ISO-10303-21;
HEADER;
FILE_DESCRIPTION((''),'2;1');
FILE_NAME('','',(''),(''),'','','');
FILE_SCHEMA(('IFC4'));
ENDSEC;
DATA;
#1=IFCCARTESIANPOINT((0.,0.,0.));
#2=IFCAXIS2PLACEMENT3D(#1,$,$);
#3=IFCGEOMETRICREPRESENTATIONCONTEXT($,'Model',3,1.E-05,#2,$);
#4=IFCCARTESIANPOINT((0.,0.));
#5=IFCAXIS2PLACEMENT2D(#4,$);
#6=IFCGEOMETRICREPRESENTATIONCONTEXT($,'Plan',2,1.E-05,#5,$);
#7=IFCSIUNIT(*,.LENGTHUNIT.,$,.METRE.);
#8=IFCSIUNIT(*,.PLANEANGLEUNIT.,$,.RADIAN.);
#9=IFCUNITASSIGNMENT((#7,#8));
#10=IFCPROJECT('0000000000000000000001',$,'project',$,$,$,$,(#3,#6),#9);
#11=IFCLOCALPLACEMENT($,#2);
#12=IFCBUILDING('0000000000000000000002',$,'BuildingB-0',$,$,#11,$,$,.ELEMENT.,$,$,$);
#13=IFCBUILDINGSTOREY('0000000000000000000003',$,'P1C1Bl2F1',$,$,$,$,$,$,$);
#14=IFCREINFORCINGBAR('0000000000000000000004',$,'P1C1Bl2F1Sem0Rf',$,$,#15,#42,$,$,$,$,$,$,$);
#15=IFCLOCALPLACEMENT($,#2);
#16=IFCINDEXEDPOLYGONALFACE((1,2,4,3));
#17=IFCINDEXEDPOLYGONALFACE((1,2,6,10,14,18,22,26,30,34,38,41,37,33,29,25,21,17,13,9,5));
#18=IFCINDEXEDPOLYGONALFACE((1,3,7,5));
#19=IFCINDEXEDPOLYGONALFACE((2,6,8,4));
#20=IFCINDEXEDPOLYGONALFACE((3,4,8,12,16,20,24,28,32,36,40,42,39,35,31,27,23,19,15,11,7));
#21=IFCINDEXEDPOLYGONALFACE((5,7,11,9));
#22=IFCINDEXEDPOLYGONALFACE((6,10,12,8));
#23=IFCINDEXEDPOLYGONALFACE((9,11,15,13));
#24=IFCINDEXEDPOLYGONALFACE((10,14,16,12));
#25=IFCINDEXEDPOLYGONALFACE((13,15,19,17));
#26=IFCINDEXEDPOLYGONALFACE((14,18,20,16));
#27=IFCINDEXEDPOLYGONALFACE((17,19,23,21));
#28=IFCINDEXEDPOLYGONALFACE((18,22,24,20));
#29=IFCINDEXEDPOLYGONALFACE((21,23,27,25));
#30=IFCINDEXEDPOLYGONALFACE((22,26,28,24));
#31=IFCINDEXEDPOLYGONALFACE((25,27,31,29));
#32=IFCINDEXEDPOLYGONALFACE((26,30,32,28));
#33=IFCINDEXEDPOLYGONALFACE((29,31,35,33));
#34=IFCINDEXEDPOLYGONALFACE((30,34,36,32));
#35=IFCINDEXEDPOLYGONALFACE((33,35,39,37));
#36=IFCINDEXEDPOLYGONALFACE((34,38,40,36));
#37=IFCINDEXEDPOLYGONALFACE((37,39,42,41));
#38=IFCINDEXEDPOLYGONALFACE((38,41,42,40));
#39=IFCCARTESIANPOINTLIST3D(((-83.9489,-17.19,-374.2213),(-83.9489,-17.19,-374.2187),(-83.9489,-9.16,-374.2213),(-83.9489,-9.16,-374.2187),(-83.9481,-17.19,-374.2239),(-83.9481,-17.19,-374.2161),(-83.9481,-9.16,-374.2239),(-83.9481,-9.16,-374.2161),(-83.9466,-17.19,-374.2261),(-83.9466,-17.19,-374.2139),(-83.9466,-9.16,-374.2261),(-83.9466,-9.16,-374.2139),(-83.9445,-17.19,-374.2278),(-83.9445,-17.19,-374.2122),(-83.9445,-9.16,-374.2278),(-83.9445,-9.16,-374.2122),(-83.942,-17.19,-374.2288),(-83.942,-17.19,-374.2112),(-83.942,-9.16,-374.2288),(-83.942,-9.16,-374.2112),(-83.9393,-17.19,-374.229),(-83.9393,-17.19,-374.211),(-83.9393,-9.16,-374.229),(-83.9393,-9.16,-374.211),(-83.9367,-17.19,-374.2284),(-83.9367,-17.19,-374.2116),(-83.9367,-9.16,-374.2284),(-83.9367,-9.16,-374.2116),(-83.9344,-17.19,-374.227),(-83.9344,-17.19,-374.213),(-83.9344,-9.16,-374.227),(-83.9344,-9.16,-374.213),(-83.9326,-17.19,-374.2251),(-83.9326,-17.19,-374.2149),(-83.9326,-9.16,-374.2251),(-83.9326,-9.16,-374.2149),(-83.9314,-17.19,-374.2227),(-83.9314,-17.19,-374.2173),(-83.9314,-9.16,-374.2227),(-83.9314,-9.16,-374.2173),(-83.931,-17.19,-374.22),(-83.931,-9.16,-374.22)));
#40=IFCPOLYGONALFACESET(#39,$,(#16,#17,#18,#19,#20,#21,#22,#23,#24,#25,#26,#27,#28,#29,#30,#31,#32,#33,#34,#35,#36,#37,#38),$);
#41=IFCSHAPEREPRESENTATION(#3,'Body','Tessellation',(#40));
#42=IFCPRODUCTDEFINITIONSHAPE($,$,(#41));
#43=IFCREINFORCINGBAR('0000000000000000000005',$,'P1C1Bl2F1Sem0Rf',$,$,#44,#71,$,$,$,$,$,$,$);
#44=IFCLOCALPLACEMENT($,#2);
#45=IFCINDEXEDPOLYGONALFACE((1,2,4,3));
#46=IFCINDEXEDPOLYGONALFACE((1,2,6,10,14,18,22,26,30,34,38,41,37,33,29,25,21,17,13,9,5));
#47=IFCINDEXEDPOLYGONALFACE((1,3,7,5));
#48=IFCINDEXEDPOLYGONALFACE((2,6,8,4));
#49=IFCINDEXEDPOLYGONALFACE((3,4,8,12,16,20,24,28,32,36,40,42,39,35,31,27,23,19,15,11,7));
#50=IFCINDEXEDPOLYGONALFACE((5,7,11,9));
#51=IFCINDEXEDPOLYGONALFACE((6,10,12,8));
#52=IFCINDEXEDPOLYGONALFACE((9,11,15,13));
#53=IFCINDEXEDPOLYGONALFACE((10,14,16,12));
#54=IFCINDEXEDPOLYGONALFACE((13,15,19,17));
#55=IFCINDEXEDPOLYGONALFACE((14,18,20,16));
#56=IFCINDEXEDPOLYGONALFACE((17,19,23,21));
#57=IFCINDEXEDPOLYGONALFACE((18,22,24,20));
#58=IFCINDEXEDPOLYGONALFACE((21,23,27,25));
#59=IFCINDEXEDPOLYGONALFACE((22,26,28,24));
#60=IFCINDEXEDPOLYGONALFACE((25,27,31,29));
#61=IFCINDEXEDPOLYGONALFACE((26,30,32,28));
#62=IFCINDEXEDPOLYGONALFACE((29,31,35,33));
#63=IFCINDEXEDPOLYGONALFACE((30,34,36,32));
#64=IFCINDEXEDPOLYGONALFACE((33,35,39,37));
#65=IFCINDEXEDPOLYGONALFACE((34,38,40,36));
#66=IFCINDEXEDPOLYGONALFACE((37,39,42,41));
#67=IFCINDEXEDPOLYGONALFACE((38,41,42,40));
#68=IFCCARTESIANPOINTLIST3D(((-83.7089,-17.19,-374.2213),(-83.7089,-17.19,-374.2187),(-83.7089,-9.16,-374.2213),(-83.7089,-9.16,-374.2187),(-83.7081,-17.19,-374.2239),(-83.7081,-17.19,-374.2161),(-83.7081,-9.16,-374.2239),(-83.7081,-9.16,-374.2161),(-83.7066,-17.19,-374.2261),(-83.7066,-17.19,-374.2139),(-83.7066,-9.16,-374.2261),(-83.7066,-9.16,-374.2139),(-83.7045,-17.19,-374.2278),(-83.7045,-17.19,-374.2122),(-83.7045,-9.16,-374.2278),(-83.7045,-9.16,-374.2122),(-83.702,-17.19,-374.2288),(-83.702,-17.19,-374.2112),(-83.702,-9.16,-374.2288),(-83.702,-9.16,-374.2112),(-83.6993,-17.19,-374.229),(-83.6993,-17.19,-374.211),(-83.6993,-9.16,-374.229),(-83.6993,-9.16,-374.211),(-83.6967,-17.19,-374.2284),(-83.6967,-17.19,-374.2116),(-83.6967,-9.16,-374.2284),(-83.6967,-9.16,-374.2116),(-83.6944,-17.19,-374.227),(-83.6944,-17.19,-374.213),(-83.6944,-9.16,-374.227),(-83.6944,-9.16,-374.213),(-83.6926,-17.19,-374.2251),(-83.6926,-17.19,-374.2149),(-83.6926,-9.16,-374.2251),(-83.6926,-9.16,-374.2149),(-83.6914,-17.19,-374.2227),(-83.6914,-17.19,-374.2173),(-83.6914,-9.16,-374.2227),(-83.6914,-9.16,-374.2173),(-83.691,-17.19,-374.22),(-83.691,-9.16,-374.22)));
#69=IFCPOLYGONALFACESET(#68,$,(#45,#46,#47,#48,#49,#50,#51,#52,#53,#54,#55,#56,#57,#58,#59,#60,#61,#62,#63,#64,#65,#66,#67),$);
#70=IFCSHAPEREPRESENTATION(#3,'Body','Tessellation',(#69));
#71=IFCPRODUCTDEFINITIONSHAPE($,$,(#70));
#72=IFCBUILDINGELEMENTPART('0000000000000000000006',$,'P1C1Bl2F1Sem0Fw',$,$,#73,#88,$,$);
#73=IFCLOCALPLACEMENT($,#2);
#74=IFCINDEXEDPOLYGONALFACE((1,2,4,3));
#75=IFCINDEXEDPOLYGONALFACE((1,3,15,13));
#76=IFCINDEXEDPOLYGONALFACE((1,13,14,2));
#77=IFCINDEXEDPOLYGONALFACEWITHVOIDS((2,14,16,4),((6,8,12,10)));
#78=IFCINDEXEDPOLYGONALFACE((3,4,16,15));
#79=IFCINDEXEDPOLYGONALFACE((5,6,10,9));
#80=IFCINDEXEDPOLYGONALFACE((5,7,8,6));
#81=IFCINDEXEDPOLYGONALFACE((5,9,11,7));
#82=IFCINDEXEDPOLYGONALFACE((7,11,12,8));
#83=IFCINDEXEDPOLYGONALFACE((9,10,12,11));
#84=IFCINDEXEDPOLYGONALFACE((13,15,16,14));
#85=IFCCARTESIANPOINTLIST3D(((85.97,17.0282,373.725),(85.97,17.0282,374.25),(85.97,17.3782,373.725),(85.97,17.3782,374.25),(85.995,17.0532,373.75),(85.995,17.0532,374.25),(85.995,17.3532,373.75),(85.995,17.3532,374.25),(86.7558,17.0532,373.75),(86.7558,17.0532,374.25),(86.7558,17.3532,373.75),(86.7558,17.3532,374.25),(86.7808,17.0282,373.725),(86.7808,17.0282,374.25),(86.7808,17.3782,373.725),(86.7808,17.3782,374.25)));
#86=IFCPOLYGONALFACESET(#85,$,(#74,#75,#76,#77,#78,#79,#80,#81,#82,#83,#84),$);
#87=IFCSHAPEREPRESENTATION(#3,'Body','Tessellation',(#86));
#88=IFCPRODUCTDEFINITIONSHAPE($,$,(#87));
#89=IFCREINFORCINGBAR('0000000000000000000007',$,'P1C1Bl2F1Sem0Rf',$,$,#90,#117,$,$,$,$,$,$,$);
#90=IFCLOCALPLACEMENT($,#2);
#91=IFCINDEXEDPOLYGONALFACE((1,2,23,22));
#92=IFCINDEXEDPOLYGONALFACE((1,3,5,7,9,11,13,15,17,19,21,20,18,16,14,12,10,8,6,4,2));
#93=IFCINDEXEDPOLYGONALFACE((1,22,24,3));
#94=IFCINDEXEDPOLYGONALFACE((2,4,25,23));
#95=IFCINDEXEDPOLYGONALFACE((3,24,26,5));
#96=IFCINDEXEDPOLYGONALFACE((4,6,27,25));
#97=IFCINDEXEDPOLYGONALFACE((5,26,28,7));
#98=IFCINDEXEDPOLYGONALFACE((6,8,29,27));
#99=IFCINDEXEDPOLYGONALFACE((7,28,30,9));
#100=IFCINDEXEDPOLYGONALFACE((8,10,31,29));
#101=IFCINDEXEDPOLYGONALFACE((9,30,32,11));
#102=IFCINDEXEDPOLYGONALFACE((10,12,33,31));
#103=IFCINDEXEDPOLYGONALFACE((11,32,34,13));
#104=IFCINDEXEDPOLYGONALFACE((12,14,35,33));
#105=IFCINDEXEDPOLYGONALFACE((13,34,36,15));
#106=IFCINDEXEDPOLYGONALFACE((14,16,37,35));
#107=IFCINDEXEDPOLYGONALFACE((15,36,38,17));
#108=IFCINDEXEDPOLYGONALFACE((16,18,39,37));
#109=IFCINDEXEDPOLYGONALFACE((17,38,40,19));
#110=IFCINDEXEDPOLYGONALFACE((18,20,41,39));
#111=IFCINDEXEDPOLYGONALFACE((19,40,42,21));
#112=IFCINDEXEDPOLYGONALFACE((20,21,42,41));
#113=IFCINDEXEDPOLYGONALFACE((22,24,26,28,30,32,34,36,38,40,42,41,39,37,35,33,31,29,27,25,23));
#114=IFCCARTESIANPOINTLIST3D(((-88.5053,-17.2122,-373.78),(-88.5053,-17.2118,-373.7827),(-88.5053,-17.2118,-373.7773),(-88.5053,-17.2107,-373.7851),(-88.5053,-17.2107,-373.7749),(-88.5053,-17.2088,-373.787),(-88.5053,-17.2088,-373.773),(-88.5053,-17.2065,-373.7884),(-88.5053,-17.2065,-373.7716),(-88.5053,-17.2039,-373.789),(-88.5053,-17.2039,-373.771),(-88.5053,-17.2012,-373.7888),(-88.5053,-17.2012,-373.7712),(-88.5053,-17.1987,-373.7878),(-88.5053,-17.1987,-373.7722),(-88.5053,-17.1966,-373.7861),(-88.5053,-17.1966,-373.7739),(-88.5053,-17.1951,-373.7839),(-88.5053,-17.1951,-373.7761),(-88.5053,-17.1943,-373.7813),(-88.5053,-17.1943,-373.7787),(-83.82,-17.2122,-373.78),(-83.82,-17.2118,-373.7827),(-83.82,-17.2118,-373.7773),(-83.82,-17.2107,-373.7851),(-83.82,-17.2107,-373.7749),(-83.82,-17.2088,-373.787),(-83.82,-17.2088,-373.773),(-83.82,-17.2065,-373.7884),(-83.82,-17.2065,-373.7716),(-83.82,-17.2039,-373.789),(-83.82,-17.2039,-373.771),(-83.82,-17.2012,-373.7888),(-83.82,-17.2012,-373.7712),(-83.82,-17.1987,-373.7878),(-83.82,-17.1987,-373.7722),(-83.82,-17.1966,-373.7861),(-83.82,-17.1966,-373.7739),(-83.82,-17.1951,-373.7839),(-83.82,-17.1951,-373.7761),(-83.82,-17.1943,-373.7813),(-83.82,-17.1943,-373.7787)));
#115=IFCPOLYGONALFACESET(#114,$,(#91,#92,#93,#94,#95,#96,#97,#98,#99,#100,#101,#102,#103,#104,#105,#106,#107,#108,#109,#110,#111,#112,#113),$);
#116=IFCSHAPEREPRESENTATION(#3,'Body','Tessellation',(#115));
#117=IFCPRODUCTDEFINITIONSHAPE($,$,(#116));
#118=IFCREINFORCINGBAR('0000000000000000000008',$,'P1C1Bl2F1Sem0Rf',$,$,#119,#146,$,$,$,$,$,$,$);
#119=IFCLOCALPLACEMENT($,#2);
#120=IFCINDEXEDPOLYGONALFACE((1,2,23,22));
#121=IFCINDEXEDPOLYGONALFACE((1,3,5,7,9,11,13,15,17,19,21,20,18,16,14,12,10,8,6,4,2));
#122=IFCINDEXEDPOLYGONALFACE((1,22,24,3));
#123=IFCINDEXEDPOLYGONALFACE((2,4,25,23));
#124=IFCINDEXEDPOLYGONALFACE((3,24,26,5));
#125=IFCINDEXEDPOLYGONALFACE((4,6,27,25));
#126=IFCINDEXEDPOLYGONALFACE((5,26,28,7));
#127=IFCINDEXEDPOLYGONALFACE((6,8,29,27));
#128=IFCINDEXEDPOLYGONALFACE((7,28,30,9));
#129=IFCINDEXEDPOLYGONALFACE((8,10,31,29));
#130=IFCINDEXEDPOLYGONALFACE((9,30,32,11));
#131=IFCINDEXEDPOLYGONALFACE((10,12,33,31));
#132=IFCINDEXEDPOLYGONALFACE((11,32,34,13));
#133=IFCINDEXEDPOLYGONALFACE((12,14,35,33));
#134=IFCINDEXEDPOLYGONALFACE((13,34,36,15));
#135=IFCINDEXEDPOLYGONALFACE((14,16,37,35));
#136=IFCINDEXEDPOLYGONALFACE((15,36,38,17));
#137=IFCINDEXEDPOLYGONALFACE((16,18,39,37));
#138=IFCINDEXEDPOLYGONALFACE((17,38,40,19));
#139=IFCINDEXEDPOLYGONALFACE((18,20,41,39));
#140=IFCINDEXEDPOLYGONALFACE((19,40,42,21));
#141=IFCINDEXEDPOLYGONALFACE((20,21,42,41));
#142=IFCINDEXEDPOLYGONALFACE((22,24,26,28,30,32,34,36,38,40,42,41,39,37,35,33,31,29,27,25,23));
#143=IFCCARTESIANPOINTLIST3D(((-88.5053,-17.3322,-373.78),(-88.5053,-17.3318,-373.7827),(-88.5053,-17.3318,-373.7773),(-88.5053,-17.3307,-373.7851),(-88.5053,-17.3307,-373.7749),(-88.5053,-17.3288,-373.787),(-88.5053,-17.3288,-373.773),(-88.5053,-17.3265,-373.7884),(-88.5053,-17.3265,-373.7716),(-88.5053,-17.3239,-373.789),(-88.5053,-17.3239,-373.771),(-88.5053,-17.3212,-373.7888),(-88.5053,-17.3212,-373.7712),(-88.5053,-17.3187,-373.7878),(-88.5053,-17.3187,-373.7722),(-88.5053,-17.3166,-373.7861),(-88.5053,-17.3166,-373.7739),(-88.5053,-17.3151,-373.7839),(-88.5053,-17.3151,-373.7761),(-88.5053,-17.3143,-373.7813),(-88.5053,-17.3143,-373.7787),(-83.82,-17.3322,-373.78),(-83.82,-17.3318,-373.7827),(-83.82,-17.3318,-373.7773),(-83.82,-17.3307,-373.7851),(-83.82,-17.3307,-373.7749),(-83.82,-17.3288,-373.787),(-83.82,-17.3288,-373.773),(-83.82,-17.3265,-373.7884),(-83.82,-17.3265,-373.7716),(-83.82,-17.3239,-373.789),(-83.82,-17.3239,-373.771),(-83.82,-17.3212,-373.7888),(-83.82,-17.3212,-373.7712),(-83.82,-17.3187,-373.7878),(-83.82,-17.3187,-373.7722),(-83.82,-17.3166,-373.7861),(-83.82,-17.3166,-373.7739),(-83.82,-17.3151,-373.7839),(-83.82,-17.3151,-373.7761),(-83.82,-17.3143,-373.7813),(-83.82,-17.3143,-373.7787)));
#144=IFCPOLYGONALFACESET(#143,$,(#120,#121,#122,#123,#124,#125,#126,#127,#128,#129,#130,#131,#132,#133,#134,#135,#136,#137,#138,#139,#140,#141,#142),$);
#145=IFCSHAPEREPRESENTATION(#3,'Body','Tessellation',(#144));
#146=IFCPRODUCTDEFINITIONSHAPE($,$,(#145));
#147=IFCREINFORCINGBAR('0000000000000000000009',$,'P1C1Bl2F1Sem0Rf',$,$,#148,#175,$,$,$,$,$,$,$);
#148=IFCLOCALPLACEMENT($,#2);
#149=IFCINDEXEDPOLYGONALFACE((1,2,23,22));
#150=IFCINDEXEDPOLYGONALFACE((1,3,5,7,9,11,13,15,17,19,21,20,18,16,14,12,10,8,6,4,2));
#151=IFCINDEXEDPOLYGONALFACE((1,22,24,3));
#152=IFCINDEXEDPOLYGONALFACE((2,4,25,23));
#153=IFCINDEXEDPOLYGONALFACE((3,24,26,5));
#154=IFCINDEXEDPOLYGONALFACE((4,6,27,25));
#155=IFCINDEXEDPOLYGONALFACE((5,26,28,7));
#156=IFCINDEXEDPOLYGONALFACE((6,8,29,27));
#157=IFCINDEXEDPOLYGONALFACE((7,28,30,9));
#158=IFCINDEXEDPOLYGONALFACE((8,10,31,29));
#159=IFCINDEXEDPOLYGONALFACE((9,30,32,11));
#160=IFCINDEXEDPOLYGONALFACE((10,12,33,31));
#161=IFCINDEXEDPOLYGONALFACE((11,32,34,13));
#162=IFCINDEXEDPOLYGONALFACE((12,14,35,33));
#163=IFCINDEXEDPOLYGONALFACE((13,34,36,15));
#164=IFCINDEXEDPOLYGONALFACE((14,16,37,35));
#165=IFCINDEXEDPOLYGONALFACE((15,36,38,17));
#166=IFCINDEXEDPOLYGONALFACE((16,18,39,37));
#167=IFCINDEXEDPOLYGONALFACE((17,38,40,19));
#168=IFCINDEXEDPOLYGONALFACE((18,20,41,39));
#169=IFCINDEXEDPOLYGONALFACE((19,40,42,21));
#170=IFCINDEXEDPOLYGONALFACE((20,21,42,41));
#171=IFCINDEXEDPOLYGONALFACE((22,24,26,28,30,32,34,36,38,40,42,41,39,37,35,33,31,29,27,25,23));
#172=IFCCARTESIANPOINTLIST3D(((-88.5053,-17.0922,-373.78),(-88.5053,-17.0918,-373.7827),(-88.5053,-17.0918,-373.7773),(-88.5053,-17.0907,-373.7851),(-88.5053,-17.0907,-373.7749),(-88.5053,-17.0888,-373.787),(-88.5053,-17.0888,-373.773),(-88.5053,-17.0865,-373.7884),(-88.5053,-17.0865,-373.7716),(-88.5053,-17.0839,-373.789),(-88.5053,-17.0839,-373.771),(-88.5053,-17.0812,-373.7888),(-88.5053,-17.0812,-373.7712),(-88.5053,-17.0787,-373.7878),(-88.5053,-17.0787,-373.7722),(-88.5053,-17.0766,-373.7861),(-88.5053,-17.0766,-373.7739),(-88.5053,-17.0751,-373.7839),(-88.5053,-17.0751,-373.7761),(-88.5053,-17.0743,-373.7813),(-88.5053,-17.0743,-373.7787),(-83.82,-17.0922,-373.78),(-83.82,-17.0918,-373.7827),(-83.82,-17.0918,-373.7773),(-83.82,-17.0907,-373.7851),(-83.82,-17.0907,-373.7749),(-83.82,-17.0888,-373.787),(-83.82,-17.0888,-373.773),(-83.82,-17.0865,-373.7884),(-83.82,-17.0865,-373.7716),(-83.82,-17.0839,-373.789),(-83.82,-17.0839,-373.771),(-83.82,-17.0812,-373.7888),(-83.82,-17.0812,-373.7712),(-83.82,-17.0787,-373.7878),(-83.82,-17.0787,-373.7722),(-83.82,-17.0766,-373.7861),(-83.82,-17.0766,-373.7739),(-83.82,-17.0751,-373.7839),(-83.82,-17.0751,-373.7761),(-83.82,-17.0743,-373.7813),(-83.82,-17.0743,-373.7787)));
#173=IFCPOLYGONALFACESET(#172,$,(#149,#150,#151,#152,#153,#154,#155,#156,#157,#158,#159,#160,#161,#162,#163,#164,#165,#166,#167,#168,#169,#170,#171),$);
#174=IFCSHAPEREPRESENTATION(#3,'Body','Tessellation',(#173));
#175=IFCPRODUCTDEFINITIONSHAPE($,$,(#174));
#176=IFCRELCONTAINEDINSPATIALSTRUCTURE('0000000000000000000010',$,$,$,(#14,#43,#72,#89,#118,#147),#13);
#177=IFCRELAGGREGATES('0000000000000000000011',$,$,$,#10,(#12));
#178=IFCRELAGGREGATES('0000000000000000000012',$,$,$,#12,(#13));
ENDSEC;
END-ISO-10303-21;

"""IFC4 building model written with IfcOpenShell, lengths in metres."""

from ifc_helpers import new_model, entity, si_unit, origin, origin_2d, place, context, project, spatial, polyline, outline, extrude, element, save


model = new_model("IFC4")

# Units and contexts
model_context = context("Model", 3, precision=1e-05, world=origin())
plan_context = context("Plan", 2, precision=1e-05, world=origin_2d())
ifc_project = project(units=[si_unit("LENGTHUNIT", "METRE"), si_unit("PLANEANGLEUNIT", "RADIAN")], contexts=[model_context, plan_context])

# Building, storey
building_placement = place(None, origin())
building = spatial("IfcBuilding", under=ifc_project, at=building_placement, Name="BuildingB-0", CompositionType="ELEMENT")
storey = spatial("IfcBuildingStorey", under=building, Name="P1C1Bl2F1")

# Reinforcing bars
element("IfcReinforcingBar", 1, inside=storey, Name="P1C1Bl2F1Sem0Rf", context=model_context, shape_type="SweptSolid", body=[
    entity("IfcSurfaceCurveSweptAreaSolid", entity("IfcCircleProfileDef", "AREA", None, None, 0.009), None, entity("IfcPolyline", [entity("IfcCartesianPoint", [83.94, 9.16, 374.22]), entity("IfcCartesianPoint", [83.94, 17.19, 374.22])]), None, None, entity("IfcPlane", entity("IfcAxis2Placement3D", entity("IfcCartesianPoint", [83.94, 9.16, 374.22]), entity("IfcDirection", [0.0, 0.0, 1.0]), entity("IfcDirection", [1.0, 0.0, 0.0])))),
])
element("IfcReinforcingBar", 2, inside=storey, Name="P1C1Bl2F1Sem0Rf", context=model_context, shape_type="SweptSolid", body=[
    entity("IfcSurfaceCurveSweptAreaSolid", entity("IfcCircleProfileDef", "AREA", None, None, 0.009), None, entity("IfcPolyline", [entity("IfcCartesianPoint", [83.7, 9.16, 374.22]), entity("IfcCartesianPoint", [83.7, 17.19, 374.22])]), None, None, entity("IfcPlane", entity("IfcAxis2Placement3D", entity("IfcCartesianPoint", [83.7, 9.16, 374.22]), entity("IfcDirection", [0.0, 0.0, 1.0]), entity("IfcDirection", [1.0, 0.0, 0.0])))),
])

# Building element part, opening
building_element_part_1 = element("IfcBuildingElementPart", 3, inside=storey, Name="P1C1Bl2F1Sem0Fw", context=model_context, shape_type="SweptSolid", body=[
    extrude(outline(polyline([(86.7808, 17.0282, 373.725), (86.7808, 17.3782, 373.725), (85.97, 17.3782, 373.725), (85.97, 17.0282, 373.725), (86.7808, 17.0282, 373.725)])), None, (0.0, 0.0, 1.0), 0.525),
])
element("IfcOpeningElement", 4, inside=storey, cuts=building_element_part_1, context=model_context, shape_type="SweptSolid", body=[
    extrude(outline(polyline([(86.7558, 17.0532, 373.75), (86.7558, 17.3532, 373.75), (85.995, 17.3532, 373.75), (85.995, 17.0532, 373.75), (86.7558, 17.0532, 373.75)])), None, (0.0, 0.0, 1.0), 0.5),
])

# Reinforcing bars
element("IfcReinforcingBar", 5, inside=storey, Name="P1C1Bl2F1Sem0Rf", context=model_context, shape_type="SweptSolid", body=[
    entity("IfcSurfaceCurveSweptAreaSolid", entity("IfcCircleProfileDef", "AREA", None, None, 0.009), None, entity("IfcPolyline", [entity("IfcCartesianPoint", [88.5053, 17.2032, 373.78]), entity("IfcCartesianPoint", [83.82, 17.2032, 373.78])]), None, None, entity("IfcPlane", entity("IfcAxis2Placement3D", entity("IfcCartesianPoint", [88.5053, 17.2032, 373.78]), entity("IfcDirection", [0.0, 0.0, 1.0]), entity("IfcDirection", [1.0, 0.0, 0.0])))),
])
element("IfcReinforcingBar", 6, inside=storey, Name="P1C1Bl2F1Sem0Rf", context=model_context, shape_type="SweptSolid", body=[
    entity("IfcSurfaceCurveSweptAreaSolid", entity("IfcCircleProfileDef", "AREA", None, None, 0.009), None, entity("IfcPolyline", [entity("IfcCartesianPoint", [88.5053, 17.3232, 373.78]), entity("IfcCartesianPoint", [83.82, 17.3232, 373.78])]), None, None, entity("IfcPlane", entity("IfcAxis2Placement3D", entity("IfcCartesianPoint", [88.5053, 17.3232, 373.78]), entity("IfcDirection", [0.0, 0.0, 1.0]), entity("IfcDirection", [1.0, 0.0, 0.0])))),
])
element("IfcReinforcingBar", 7, inside=storey, Name="P1C1Bl2F1Sem0Rf", context=model_context, shape_type="SweptSolid", body=[
    entity("IfcSurfaceCurveSweptAreaSolid", entity("IfcCircleProfileDef", "AREA", None, None, 0.009), None, entity("IfcPolyline", [entity("IfcCartesianPoint", [88.5053, 17.0832, 373.78]), entity("IfcCartesianPoint", [83.82, 17.0832, 373.78])]), None, None, entity("IfcPlane", entity("IfcAxis2Placement3D", entity("IfcCartesianPoint", [88.5053, 17.0832, 373.78]), entity("IfcDirection", [0.0, 0.0, 1.0]), entity("IfcDirection", [1.0, 0.0, 0.0])))),
])

save(model, "model.ifc")
